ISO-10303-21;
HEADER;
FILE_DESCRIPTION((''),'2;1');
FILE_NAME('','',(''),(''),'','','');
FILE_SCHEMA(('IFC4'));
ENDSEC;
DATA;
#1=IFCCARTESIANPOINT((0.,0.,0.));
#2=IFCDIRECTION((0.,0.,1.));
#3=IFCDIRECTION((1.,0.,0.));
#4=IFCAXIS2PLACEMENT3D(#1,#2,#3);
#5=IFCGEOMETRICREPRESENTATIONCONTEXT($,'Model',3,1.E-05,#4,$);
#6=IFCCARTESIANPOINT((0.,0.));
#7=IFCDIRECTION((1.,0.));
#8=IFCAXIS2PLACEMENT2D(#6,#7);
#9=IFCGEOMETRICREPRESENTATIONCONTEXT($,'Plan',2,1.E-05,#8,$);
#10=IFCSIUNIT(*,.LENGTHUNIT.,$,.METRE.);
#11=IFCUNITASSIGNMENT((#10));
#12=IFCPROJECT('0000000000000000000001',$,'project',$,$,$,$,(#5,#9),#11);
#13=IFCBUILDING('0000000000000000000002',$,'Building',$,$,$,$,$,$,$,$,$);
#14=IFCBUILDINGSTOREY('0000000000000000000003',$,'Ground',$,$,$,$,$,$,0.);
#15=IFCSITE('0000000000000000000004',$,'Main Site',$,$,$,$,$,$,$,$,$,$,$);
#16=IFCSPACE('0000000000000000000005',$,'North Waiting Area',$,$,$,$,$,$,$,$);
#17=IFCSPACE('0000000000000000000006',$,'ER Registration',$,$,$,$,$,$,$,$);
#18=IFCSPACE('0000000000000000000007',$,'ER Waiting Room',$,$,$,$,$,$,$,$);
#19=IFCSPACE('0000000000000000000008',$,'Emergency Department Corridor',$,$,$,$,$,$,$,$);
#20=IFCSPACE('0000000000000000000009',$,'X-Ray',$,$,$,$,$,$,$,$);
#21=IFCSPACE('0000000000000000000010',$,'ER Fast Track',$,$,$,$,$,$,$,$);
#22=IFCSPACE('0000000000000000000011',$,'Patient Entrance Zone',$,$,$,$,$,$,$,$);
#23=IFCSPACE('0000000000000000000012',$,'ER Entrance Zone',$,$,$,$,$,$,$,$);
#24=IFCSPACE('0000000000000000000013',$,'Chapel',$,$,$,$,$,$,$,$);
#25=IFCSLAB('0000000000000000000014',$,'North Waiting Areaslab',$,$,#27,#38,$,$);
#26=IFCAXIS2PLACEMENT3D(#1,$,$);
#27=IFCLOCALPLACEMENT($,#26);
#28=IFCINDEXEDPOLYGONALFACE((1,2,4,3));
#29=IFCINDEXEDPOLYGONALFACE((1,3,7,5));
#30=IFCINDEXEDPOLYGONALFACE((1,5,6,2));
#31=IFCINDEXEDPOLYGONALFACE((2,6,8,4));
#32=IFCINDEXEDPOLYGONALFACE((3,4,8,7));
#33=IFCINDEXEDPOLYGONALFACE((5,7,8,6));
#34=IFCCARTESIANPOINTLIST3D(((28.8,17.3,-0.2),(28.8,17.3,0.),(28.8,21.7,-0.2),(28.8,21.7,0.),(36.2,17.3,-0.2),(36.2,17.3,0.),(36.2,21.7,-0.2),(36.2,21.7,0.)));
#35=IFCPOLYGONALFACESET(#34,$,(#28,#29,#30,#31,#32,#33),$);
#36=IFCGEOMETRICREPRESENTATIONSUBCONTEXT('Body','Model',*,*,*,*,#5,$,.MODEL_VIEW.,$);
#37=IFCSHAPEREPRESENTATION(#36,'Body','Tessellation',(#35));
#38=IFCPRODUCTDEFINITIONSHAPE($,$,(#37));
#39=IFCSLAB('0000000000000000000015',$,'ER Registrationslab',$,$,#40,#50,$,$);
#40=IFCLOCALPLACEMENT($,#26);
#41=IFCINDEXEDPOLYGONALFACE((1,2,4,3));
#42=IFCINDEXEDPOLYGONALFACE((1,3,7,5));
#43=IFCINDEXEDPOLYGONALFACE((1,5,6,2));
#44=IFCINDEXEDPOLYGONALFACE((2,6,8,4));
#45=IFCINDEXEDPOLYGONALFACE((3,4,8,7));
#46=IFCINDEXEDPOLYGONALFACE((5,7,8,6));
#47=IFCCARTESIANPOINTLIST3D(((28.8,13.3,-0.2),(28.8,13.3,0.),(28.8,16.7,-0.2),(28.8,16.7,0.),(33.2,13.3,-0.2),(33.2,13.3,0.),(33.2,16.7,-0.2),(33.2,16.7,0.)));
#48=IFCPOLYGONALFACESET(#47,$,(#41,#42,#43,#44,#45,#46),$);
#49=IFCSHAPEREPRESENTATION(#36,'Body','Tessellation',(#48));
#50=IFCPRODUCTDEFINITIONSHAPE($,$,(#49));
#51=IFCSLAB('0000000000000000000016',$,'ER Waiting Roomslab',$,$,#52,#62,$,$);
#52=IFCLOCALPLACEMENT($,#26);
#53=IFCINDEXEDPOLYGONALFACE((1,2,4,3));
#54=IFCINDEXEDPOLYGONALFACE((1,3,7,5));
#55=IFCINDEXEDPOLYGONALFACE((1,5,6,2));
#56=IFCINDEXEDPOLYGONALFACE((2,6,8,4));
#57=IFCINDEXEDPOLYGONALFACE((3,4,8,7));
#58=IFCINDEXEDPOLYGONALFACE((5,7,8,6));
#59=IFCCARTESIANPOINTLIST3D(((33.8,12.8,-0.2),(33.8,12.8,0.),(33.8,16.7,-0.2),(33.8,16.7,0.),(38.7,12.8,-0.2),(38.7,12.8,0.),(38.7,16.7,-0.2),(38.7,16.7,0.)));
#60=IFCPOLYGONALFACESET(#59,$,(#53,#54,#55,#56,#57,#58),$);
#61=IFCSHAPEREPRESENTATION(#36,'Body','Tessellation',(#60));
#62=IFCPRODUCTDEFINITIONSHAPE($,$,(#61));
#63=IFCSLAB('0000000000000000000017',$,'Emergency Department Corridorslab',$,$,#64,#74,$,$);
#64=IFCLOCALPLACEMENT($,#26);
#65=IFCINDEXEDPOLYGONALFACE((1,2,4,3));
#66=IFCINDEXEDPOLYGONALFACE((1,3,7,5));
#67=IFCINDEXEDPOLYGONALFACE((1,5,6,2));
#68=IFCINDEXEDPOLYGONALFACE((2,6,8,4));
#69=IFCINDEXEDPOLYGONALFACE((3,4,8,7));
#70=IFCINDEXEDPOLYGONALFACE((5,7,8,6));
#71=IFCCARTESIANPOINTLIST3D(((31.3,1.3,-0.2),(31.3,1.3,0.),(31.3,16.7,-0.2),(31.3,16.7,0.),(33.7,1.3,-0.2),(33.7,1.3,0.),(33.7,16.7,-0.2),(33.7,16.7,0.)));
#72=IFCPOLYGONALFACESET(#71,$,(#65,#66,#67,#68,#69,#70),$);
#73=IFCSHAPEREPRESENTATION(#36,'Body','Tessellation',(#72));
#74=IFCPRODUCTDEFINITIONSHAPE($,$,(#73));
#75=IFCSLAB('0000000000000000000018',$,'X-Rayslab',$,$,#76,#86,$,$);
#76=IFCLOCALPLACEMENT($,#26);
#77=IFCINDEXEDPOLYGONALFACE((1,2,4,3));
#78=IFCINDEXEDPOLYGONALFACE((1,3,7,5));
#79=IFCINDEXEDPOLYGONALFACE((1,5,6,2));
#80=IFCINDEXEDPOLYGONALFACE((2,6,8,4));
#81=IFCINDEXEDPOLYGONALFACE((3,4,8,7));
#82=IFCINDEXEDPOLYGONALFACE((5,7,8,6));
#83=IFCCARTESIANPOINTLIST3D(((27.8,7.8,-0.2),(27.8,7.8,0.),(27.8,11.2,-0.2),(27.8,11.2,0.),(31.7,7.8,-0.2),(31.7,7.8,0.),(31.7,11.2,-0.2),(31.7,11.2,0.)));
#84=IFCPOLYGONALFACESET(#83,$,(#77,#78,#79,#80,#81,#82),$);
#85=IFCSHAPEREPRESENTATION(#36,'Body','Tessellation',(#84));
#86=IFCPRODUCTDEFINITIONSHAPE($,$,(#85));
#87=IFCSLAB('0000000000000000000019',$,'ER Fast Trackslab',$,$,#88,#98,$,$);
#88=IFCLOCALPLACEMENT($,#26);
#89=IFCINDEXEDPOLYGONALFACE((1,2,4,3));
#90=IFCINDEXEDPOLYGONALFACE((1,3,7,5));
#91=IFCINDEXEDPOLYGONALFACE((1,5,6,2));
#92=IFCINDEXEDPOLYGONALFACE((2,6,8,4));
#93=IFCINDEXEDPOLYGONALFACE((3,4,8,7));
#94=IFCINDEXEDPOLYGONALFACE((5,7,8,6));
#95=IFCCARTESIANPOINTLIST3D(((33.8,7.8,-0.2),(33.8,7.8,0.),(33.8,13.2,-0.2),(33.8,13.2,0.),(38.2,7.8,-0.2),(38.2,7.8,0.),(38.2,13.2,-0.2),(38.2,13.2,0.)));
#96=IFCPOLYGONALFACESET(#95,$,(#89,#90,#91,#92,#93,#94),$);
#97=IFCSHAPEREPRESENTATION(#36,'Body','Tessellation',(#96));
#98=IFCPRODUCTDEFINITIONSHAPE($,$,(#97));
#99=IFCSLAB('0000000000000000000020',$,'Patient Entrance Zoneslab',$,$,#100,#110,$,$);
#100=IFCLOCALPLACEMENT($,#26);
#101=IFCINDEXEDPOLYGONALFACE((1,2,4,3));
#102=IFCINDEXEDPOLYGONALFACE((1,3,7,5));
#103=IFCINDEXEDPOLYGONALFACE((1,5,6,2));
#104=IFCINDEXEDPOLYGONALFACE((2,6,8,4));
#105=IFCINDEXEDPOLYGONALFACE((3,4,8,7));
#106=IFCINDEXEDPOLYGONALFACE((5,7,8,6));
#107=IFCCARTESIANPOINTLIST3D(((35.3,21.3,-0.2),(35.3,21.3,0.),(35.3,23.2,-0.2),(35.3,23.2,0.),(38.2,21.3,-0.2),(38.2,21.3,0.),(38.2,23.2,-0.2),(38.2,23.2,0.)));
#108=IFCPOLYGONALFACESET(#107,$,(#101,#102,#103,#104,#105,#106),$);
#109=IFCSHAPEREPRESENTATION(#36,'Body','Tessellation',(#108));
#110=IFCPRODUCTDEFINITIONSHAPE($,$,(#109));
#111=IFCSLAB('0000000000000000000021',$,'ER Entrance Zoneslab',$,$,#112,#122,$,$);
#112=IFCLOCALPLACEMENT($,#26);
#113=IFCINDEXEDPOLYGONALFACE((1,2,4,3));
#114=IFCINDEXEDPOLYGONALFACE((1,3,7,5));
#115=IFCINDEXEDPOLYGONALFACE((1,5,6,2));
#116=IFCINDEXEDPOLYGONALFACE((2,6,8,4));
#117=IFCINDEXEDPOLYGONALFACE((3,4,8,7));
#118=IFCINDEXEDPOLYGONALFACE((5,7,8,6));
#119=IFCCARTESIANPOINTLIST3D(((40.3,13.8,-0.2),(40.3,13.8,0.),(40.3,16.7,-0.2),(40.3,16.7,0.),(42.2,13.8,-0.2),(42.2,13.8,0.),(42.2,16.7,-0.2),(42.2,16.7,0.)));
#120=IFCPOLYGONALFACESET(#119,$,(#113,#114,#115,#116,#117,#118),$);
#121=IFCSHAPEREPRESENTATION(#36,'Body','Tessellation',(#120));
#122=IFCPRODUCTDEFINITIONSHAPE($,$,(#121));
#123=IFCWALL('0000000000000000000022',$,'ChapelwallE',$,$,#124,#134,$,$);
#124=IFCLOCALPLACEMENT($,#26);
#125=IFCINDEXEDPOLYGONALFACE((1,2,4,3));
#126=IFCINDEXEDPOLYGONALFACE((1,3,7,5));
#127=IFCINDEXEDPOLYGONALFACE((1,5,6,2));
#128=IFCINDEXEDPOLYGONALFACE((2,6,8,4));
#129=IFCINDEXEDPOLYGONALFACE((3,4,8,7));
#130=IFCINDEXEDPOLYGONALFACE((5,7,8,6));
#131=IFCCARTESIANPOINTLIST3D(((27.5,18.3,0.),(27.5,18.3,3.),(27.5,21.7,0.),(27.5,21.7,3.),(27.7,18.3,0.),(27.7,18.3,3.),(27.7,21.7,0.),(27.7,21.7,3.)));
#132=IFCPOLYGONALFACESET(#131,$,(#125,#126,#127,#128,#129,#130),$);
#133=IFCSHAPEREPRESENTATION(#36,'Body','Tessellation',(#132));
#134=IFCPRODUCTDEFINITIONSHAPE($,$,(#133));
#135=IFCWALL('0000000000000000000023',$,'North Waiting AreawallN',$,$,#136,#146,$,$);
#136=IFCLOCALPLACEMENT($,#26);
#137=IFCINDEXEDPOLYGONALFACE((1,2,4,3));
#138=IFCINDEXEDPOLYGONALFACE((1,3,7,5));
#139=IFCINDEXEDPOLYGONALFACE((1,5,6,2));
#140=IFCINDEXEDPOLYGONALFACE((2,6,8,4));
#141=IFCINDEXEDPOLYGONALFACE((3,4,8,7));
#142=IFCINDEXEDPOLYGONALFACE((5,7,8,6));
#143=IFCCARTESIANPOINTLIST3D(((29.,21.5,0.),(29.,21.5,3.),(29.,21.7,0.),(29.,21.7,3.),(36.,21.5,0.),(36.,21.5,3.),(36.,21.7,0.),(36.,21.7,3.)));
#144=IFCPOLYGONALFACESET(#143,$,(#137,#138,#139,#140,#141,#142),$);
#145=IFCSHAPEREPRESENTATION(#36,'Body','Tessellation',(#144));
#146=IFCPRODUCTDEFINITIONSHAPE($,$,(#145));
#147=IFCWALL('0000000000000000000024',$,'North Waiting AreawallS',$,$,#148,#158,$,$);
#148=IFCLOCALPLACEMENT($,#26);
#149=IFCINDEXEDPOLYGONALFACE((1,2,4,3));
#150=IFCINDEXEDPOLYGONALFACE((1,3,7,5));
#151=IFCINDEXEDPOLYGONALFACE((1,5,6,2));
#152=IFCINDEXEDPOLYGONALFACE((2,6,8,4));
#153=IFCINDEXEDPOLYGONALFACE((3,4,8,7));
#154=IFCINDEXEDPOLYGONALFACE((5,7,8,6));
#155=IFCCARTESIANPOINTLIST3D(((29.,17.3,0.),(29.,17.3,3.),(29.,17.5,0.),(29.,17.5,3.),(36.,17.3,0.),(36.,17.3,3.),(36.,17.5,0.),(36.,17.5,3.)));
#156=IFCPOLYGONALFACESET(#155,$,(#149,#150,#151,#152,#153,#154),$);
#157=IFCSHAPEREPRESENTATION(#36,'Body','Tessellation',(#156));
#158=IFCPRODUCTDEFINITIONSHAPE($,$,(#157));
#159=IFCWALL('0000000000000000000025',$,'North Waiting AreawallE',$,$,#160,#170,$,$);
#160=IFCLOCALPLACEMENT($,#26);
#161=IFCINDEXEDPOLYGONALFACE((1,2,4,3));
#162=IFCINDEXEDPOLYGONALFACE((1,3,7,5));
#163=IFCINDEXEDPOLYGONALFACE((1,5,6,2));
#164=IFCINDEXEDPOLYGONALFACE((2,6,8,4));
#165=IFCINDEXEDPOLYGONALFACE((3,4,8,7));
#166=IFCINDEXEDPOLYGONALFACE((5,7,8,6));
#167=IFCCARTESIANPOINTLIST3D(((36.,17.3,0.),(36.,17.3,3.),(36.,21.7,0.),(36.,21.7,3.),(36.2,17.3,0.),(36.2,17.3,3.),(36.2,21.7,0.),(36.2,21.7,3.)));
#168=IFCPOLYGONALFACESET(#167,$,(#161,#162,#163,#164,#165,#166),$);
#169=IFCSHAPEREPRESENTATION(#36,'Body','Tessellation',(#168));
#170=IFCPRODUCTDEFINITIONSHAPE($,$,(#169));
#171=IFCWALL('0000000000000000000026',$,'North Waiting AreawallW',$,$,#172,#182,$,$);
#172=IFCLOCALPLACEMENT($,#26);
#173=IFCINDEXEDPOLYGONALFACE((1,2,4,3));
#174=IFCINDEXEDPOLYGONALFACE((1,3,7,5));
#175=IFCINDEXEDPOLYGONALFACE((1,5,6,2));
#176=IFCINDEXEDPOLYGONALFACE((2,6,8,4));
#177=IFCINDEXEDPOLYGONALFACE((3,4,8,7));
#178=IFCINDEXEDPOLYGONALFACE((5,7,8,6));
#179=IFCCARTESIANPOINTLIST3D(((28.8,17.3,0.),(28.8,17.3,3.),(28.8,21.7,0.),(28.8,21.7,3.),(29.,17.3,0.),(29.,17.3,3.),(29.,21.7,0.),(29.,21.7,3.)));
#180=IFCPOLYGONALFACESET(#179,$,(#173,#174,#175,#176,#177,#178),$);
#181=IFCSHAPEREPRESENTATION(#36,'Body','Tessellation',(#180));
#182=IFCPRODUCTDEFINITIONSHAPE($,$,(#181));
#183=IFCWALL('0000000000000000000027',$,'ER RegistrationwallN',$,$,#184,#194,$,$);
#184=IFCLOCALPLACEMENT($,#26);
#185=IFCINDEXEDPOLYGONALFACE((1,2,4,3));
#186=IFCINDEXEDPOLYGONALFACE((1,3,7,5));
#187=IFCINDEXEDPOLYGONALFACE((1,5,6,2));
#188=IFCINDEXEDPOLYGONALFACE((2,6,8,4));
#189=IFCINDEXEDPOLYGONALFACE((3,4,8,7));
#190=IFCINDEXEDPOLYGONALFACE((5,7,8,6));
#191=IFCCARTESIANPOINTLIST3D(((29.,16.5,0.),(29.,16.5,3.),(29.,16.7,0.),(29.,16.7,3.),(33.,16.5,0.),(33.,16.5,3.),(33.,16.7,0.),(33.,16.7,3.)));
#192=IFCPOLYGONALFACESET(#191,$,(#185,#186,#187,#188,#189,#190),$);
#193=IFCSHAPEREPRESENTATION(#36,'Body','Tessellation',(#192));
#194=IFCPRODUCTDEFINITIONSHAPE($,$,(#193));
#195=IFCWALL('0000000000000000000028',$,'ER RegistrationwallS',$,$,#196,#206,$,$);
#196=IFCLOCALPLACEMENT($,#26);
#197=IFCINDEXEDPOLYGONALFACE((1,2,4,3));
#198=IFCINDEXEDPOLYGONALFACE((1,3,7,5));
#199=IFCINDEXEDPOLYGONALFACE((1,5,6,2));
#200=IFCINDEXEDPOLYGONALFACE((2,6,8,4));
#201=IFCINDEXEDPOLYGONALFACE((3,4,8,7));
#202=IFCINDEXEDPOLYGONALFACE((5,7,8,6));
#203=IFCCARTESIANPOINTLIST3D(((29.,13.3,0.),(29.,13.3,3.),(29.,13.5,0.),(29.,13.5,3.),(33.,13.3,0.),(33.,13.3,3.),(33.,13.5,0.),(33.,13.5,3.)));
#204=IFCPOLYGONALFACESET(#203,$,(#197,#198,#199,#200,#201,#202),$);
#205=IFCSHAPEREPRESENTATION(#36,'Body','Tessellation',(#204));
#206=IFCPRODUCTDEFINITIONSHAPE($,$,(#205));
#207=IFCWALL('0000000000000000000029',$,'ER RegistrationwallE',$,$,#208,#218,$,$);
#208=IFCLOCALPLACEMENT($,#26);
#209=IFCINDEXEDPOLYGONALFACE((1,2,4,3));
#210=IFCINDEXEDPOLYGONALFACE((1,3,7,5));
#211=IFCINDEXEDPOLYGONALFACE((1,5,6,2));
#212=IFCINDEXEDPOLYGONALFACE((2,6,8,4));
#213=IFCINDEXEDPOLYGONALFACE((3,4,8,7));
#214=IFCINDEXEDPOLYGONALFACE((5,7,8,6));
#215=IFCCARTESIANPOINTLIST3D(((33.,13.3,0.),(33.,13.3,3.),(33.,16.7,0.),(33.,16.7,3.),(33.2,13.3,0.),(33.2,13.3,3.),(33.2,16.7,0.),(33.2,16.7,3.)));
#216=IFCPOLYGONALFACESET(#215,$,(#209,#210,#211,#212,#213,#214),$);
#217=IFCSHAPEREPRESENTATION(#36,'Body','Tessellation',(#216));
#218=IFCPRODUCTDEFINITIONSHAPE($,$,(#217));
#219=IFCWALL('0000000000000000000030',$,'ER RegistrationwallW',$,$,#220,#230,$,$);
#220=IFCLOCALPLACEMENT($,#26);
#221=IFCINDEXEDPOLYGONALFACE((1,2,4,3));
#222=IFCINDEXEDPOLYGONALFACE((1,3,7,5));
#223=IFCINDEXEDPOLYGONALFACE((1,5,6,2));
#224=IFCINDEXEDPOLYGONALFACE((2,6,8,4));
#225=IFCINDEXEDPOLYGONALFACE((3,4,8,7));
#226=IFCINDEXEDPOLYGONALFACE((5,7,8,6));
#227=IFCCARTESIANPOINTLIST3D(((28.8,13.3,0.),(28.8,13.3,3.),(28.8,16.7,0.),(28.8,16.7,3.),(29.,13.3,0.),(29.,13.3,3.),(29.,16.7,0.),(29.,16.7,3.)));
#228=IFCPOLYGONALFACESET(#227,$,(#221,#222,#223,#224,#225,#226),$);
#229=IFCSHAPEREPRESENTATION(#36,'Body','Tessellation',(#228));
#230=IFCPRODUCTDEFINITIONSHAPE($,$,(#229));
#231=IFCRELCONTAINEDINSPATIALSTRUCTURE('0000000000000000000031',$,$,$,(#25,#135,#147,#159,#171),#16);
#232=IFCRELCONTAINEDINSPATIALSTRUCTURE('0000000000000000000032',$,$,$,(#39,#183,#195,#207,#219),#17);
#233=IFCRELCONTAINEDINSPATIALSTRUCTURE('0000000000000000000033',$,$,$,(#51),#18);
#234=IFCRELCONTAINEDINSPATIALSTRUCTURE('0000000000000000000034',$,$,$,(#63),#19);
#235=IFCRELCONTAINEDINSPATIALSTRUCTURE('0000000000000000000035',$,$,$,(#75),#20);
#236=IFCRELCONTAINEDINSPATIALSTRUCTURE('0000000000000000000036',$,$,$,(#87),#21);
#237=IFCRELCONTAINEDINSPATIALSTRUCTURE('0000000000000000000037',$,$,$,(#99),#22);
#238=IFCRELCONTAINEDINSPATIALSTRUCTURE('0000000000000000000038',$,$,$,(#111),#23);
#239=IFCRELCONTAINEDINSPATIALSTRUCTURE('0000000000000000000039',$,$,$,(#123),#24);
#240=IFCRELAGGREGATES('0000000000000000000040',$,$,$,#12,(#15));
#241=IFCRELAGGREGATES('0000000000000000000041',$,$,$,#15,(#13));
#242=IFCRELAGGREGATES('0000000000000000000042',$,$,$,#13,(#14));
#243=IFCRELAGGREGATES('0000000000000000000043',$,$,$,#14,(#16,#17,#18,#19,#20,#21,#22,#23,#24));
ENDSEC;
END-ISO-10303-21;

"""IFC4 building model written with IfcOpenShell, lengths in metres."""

from ifc_helpers import new_model, si_unit, frame, origin_with_axes, origin_2d_with_axis, place, context, subcontext, project, spatial, indexed_curve, rectangle, outline, extrude, element, save


model = new_model("IFC4")

# Units and contexts
model_context = context("Model", 3, precision=1e-05, world=origin_with_axes())
plan_context = context("Plan", 2, precision=1e-05, world=origin_2d_with_axis())
body_context = subcontext(model_context, "Body", "Model", "MODEL_VIEW")
ifc_project = project(units=[si_unit("LENGTHUNIT", "METRE")], contexts=[model_context, plan_context])

# Site, building, storey, space
site = spatial("IfcSite", under=ifc_project, Name="Main Site")
building = spatial("IfcBuilding", under=site, Name="Building")
storey = spatial("IfcBuildingStorey", under=building, Name="Ground", Elevation=0.0)
space_1 = spatial("IfcSpace", under=storey, Name="North Waiting Area")

# Slab
slab_1_placement = place(None, frame((32.5, 19.5, -0.2), z_axis=(0.0, 0.0, 1.0), x_axis=(1.0, 0.0, 0.0)))
element("IfcSlab", 1, at=slab_1_placement, inside=space_1, Name="North Waiting Areaslab", context=body_context, shape_type="SweptSolid", body=[
    extrude(rectangle(XDim=7.4, YDim=4.4), origin_with_axes(), (0.0, 0.0, 1.0), 0.2),
])

# Shared definitions
space_2 = spatial("IfcSpace", under=storey, Name="ER Registration")

# Slab
slab_2_placement = place(None, frame((31.0, 15.0, -0.2), z_axis=(0.0, 0.0, 1.0), x_axis=(1.0, 0.0, 0.0)))
element("IfcSlab", 2, at=slab_2_placement, inside=space_2, Name="ER Registrationslab", context=body_context, shape_type="SweptSolid", body=[
    extrude(rectangle(XDim=4.4, YDim=3.4), origin_with_axes(), (0.0, 0.0, 1.0), 0.2),
])

# Shared definitions
space_3 = spatial("IfcSpace", under=storey, Name="ER Waiting Room")

# Slab
slab_3_placement = place(None, frame((36.25, 14.75, -0.2), z_axis=(0.0, 0.0, 1.0), x_axis=(1.0, 0.0, 0.0)))
element("IfcSlab", 3, at=slab_3_placement, inside=space_3, Name="ER Waiting Roomslab", context=body_context, shape_type="SweptSolid", body=[
    extrude(rectangle(XDim=4.9, YDim=3.9), origin_with_axes(), (0.0, 0.0, 1.0), 0.2),
])

# Shared definitions
space_4 = spatial("IfcSpace", under=storey, Name="Emergency Department Corridor")

# Slab
slab_4_placement = place(None, frame((32.5, 9.0, -0.2), z_axis=(0.0, 0.0, 1.0), x_axis=(1.0, 0.0, 0.0)))
element("IfcSlab", 4, at=slab_4_placement, inside=space_4, Name="Emergency Department Corridorslab", context=body_context, shape_type="SweptSolid", body=[
    extrude(rectangle(XDim=2.4, YDim=15.4), origin_with_axes(), (0.0, 0.0, 1.0), 0.2),
])

# Shared definitions
space_5 = spatial("IfcSpace", under=storey, Name="X-Ray")

# Slab
slab_5_placement = place(None, frame((29.75, 9.5, -0.2), z_axis=(0.0, 0.0, 1.0), x_axis=(1.0, 0.0, 0.0)))
element("IfcSlab", 5, at=slab_5_placement, inside=space_5, Name="X-Rayslab", context=body_context, shape_type="SweptSolid", body=[
    extrude(rectangle(XDim=3.9, YDim=3.4), origin_with_axes(), (0.0, 0.0, 1.0), 0.2),
])

# Shared definitions
space_6 = spatial("IfcSpace", under=storey, Name="ER Fast Track")

# Slab
slab_6_placement = place(None, frame((36.0, 10.5, -0.2), z_axis=(0.0, 0.0, 1.0), x_axis=(1.0, 0.0, 0.0)))
element("IfcSlab", 6, at=slab_6_placement, inside=space_6, Name="ER Fast Trackslab", context=body_context, shape_type="SweptSolid", body=[
    extrude(rectangle(XDim=4.4, YDim=5.4), origin_with_axes(), (0.0, 0.0, 1.0), 0.2),
])

# Shared definitions
space_7 = spatial("IfcSpace", under=storey, Name="Patient Entrance Zone")

# Slab
slab_7_placement = place(None, frame((36.75, 22.25, -0.2), z_axis=(0.0, 0.0, 1.0), x_axis=(1.0, 0.0, 0.0)))
element("IfcSlab", 7, at=slab_7_placement, inside=space_7, Name="Patient Entrance Zoneslab", context=body_context, shape_type="SweptSolid", body=[
    extrude(rectangle(XDim=2.9, YDim=1.9), origin_with_axes(), (0.0, 0.0, 1.0), 0.2),
])

# Shared definitions
space_8 = spatial("IfcSpace", under=storey, Name="ER Entrance Zone")

# Slab
slab_8_placement = place(None, frame((41.25, 15.25, -0.2), z_axis=(0.0, 0.0, 1.0), x_axis=(1.0, 0.0, 0.0)))
element("IfcSlab", 8, at=slab_8_placement, inside=space_8, Name="ER Entrance Zoneslab", context=body_context, shape_type="SweptSolid", body=[
    extrude(rectangle(XDim=1.9, YDim=2.9), origin_with_axes(), (0.0, 0.0, 1.0), 0.2),
])

# Shared definitions
space_9 = spatial("IfcSpace", under=storey, Name="Chapel")

# Walls
wall_1_placement = place(None, frame((27.7, 18.3, 0.0), z_axis=(0.0, 0.0, 1.0), x_axis=(0.0, 1.0, 0.0)))
element("IfcWall", 9, at=wall_1_placement, inside=space_9, Name="ChapelwallE", context=body_context, shape_type="SweptSolid", body=[
    extrude(outline(indexed_curve([(0.0, 0.0), (0.0, 0.2), (3.4, 0.2), (3.4, 0.0), (0.0, 0.0)], self_intersect=False)), origin_with_axes(), (0.0, 0.0, 1.0), 3.0),
])
for number, where, z_axis, x_axis, name in (
    (10, (29.0, 21.5, 0.0), (0.0, 0.0, 1.0), (1.0, 0.0, 0.0), "North Waiting AreawallN"),
    (11, (29.0, 17.3, 0.0), (0.0, 0.0, 1.0), (1.0, 0.0, 0.0), "North Waiting AreawallS"),
):
    element("IfcWall", number, at=place(None, frame(where, z_axis=z_axis, x_axis=x_axis)), inside=space_1, Name=name, context=body_context, shape_type="SweptSolid", body=[
        extrude(outline(indexed_curve([(0.0, 0.0), (0.0, 0.2), (7.0, 0.2), (7.0, 0.0), (0.0, 0.0)], self_intersect=False)), origin_with_axes(), (0.0, 0.0, 1.0), 3.0),
    ])
for number, where, z_axis, x_axis, name in (
    (12, (36.2, 17.3, 0.0), (0.0, 0.0, 1.0), (0.0, 1.0, 0.0), "North Waiting AreawallE"),
    (13, (29.0, 17.3, 0.0), (0.0, 0.0, 1.0), (0.0, 1.0, 0.0), "North Waiting AreawallW"),
):
    element("IfcWall", number, at=place(None, frame(where, z_axis=z_axis, x_axis=x_axis)), inside=space_1, Name=name, context=body_context, shape_type="SweptSolid", body=[
        extrude(outline(indexed_curve([(0.0, 0.0), (0.0, 0.2), (4.4, 0.2), (4.4, 0.0), (0.0, 0.0)], self_intersect=False)), origin_with_axes(), (0.0, 0.0, 1.0), 3.0),
    ])
for number, where, z_axis, x_axis, name in (
    (14, (29.0, 16.5, 0.0), (0.0, 0.0, 1.0), (1.0, 0.0, 0.0), "ER RegistrationwallN"),
    (15, (29.0, 13.3, 0.0), (0.0, 0.0, 1.0), (1.0, 0.0, 0.0), "ER RegistrationwallS"),
):
    element("IfcWall", number, at=place(None, frame(where, z_axis=z_axis, x_axis=x_axis)), inside=space_2, Name=name, context=body_context, shape_type="SweptSolid", body=[
        extrude(outline(indexed_curve([(0.0, 0.0), (0.0, 0.2), (4.0, 0.2), (4.0, 0.0), (0.0, 0.0)], self_intersect=False)), origin_with_axes(), (0.0, 0.0, 1.0), 3.0),
    ])
for number, where, z_axis, x_axis, name in (
    (16, (33.2, 13.3, 0.0), (0.0, 0.0, 1.0), (0.0, 1.0, 0.0), "ER RegistrationwallE"),
    (17, (29.0, 13.3, 0.0), (0.0, 0.0, 1.0), (0.0, 1.0, 0.0), "ER RegistrationwallW"),
):
    element("IfcWall", number, at=place(None, frame(where, z_axis=z_axis, x_axis=x_axis)), inside=space_2, Name=name, context=body_context, shape_type="SweptSolid", body=[
        extrude(outline(indexed_curve([(0.0, 0.0), (0.0, 0.2), (3.4, 0.2), (3.4, 0.0), (0.0, 0.0)], self_intersect=False)), origin_with_axes(), (0.0, 0.0, 1.0), 3.0),
    ])

save(model, "model.ifc")
